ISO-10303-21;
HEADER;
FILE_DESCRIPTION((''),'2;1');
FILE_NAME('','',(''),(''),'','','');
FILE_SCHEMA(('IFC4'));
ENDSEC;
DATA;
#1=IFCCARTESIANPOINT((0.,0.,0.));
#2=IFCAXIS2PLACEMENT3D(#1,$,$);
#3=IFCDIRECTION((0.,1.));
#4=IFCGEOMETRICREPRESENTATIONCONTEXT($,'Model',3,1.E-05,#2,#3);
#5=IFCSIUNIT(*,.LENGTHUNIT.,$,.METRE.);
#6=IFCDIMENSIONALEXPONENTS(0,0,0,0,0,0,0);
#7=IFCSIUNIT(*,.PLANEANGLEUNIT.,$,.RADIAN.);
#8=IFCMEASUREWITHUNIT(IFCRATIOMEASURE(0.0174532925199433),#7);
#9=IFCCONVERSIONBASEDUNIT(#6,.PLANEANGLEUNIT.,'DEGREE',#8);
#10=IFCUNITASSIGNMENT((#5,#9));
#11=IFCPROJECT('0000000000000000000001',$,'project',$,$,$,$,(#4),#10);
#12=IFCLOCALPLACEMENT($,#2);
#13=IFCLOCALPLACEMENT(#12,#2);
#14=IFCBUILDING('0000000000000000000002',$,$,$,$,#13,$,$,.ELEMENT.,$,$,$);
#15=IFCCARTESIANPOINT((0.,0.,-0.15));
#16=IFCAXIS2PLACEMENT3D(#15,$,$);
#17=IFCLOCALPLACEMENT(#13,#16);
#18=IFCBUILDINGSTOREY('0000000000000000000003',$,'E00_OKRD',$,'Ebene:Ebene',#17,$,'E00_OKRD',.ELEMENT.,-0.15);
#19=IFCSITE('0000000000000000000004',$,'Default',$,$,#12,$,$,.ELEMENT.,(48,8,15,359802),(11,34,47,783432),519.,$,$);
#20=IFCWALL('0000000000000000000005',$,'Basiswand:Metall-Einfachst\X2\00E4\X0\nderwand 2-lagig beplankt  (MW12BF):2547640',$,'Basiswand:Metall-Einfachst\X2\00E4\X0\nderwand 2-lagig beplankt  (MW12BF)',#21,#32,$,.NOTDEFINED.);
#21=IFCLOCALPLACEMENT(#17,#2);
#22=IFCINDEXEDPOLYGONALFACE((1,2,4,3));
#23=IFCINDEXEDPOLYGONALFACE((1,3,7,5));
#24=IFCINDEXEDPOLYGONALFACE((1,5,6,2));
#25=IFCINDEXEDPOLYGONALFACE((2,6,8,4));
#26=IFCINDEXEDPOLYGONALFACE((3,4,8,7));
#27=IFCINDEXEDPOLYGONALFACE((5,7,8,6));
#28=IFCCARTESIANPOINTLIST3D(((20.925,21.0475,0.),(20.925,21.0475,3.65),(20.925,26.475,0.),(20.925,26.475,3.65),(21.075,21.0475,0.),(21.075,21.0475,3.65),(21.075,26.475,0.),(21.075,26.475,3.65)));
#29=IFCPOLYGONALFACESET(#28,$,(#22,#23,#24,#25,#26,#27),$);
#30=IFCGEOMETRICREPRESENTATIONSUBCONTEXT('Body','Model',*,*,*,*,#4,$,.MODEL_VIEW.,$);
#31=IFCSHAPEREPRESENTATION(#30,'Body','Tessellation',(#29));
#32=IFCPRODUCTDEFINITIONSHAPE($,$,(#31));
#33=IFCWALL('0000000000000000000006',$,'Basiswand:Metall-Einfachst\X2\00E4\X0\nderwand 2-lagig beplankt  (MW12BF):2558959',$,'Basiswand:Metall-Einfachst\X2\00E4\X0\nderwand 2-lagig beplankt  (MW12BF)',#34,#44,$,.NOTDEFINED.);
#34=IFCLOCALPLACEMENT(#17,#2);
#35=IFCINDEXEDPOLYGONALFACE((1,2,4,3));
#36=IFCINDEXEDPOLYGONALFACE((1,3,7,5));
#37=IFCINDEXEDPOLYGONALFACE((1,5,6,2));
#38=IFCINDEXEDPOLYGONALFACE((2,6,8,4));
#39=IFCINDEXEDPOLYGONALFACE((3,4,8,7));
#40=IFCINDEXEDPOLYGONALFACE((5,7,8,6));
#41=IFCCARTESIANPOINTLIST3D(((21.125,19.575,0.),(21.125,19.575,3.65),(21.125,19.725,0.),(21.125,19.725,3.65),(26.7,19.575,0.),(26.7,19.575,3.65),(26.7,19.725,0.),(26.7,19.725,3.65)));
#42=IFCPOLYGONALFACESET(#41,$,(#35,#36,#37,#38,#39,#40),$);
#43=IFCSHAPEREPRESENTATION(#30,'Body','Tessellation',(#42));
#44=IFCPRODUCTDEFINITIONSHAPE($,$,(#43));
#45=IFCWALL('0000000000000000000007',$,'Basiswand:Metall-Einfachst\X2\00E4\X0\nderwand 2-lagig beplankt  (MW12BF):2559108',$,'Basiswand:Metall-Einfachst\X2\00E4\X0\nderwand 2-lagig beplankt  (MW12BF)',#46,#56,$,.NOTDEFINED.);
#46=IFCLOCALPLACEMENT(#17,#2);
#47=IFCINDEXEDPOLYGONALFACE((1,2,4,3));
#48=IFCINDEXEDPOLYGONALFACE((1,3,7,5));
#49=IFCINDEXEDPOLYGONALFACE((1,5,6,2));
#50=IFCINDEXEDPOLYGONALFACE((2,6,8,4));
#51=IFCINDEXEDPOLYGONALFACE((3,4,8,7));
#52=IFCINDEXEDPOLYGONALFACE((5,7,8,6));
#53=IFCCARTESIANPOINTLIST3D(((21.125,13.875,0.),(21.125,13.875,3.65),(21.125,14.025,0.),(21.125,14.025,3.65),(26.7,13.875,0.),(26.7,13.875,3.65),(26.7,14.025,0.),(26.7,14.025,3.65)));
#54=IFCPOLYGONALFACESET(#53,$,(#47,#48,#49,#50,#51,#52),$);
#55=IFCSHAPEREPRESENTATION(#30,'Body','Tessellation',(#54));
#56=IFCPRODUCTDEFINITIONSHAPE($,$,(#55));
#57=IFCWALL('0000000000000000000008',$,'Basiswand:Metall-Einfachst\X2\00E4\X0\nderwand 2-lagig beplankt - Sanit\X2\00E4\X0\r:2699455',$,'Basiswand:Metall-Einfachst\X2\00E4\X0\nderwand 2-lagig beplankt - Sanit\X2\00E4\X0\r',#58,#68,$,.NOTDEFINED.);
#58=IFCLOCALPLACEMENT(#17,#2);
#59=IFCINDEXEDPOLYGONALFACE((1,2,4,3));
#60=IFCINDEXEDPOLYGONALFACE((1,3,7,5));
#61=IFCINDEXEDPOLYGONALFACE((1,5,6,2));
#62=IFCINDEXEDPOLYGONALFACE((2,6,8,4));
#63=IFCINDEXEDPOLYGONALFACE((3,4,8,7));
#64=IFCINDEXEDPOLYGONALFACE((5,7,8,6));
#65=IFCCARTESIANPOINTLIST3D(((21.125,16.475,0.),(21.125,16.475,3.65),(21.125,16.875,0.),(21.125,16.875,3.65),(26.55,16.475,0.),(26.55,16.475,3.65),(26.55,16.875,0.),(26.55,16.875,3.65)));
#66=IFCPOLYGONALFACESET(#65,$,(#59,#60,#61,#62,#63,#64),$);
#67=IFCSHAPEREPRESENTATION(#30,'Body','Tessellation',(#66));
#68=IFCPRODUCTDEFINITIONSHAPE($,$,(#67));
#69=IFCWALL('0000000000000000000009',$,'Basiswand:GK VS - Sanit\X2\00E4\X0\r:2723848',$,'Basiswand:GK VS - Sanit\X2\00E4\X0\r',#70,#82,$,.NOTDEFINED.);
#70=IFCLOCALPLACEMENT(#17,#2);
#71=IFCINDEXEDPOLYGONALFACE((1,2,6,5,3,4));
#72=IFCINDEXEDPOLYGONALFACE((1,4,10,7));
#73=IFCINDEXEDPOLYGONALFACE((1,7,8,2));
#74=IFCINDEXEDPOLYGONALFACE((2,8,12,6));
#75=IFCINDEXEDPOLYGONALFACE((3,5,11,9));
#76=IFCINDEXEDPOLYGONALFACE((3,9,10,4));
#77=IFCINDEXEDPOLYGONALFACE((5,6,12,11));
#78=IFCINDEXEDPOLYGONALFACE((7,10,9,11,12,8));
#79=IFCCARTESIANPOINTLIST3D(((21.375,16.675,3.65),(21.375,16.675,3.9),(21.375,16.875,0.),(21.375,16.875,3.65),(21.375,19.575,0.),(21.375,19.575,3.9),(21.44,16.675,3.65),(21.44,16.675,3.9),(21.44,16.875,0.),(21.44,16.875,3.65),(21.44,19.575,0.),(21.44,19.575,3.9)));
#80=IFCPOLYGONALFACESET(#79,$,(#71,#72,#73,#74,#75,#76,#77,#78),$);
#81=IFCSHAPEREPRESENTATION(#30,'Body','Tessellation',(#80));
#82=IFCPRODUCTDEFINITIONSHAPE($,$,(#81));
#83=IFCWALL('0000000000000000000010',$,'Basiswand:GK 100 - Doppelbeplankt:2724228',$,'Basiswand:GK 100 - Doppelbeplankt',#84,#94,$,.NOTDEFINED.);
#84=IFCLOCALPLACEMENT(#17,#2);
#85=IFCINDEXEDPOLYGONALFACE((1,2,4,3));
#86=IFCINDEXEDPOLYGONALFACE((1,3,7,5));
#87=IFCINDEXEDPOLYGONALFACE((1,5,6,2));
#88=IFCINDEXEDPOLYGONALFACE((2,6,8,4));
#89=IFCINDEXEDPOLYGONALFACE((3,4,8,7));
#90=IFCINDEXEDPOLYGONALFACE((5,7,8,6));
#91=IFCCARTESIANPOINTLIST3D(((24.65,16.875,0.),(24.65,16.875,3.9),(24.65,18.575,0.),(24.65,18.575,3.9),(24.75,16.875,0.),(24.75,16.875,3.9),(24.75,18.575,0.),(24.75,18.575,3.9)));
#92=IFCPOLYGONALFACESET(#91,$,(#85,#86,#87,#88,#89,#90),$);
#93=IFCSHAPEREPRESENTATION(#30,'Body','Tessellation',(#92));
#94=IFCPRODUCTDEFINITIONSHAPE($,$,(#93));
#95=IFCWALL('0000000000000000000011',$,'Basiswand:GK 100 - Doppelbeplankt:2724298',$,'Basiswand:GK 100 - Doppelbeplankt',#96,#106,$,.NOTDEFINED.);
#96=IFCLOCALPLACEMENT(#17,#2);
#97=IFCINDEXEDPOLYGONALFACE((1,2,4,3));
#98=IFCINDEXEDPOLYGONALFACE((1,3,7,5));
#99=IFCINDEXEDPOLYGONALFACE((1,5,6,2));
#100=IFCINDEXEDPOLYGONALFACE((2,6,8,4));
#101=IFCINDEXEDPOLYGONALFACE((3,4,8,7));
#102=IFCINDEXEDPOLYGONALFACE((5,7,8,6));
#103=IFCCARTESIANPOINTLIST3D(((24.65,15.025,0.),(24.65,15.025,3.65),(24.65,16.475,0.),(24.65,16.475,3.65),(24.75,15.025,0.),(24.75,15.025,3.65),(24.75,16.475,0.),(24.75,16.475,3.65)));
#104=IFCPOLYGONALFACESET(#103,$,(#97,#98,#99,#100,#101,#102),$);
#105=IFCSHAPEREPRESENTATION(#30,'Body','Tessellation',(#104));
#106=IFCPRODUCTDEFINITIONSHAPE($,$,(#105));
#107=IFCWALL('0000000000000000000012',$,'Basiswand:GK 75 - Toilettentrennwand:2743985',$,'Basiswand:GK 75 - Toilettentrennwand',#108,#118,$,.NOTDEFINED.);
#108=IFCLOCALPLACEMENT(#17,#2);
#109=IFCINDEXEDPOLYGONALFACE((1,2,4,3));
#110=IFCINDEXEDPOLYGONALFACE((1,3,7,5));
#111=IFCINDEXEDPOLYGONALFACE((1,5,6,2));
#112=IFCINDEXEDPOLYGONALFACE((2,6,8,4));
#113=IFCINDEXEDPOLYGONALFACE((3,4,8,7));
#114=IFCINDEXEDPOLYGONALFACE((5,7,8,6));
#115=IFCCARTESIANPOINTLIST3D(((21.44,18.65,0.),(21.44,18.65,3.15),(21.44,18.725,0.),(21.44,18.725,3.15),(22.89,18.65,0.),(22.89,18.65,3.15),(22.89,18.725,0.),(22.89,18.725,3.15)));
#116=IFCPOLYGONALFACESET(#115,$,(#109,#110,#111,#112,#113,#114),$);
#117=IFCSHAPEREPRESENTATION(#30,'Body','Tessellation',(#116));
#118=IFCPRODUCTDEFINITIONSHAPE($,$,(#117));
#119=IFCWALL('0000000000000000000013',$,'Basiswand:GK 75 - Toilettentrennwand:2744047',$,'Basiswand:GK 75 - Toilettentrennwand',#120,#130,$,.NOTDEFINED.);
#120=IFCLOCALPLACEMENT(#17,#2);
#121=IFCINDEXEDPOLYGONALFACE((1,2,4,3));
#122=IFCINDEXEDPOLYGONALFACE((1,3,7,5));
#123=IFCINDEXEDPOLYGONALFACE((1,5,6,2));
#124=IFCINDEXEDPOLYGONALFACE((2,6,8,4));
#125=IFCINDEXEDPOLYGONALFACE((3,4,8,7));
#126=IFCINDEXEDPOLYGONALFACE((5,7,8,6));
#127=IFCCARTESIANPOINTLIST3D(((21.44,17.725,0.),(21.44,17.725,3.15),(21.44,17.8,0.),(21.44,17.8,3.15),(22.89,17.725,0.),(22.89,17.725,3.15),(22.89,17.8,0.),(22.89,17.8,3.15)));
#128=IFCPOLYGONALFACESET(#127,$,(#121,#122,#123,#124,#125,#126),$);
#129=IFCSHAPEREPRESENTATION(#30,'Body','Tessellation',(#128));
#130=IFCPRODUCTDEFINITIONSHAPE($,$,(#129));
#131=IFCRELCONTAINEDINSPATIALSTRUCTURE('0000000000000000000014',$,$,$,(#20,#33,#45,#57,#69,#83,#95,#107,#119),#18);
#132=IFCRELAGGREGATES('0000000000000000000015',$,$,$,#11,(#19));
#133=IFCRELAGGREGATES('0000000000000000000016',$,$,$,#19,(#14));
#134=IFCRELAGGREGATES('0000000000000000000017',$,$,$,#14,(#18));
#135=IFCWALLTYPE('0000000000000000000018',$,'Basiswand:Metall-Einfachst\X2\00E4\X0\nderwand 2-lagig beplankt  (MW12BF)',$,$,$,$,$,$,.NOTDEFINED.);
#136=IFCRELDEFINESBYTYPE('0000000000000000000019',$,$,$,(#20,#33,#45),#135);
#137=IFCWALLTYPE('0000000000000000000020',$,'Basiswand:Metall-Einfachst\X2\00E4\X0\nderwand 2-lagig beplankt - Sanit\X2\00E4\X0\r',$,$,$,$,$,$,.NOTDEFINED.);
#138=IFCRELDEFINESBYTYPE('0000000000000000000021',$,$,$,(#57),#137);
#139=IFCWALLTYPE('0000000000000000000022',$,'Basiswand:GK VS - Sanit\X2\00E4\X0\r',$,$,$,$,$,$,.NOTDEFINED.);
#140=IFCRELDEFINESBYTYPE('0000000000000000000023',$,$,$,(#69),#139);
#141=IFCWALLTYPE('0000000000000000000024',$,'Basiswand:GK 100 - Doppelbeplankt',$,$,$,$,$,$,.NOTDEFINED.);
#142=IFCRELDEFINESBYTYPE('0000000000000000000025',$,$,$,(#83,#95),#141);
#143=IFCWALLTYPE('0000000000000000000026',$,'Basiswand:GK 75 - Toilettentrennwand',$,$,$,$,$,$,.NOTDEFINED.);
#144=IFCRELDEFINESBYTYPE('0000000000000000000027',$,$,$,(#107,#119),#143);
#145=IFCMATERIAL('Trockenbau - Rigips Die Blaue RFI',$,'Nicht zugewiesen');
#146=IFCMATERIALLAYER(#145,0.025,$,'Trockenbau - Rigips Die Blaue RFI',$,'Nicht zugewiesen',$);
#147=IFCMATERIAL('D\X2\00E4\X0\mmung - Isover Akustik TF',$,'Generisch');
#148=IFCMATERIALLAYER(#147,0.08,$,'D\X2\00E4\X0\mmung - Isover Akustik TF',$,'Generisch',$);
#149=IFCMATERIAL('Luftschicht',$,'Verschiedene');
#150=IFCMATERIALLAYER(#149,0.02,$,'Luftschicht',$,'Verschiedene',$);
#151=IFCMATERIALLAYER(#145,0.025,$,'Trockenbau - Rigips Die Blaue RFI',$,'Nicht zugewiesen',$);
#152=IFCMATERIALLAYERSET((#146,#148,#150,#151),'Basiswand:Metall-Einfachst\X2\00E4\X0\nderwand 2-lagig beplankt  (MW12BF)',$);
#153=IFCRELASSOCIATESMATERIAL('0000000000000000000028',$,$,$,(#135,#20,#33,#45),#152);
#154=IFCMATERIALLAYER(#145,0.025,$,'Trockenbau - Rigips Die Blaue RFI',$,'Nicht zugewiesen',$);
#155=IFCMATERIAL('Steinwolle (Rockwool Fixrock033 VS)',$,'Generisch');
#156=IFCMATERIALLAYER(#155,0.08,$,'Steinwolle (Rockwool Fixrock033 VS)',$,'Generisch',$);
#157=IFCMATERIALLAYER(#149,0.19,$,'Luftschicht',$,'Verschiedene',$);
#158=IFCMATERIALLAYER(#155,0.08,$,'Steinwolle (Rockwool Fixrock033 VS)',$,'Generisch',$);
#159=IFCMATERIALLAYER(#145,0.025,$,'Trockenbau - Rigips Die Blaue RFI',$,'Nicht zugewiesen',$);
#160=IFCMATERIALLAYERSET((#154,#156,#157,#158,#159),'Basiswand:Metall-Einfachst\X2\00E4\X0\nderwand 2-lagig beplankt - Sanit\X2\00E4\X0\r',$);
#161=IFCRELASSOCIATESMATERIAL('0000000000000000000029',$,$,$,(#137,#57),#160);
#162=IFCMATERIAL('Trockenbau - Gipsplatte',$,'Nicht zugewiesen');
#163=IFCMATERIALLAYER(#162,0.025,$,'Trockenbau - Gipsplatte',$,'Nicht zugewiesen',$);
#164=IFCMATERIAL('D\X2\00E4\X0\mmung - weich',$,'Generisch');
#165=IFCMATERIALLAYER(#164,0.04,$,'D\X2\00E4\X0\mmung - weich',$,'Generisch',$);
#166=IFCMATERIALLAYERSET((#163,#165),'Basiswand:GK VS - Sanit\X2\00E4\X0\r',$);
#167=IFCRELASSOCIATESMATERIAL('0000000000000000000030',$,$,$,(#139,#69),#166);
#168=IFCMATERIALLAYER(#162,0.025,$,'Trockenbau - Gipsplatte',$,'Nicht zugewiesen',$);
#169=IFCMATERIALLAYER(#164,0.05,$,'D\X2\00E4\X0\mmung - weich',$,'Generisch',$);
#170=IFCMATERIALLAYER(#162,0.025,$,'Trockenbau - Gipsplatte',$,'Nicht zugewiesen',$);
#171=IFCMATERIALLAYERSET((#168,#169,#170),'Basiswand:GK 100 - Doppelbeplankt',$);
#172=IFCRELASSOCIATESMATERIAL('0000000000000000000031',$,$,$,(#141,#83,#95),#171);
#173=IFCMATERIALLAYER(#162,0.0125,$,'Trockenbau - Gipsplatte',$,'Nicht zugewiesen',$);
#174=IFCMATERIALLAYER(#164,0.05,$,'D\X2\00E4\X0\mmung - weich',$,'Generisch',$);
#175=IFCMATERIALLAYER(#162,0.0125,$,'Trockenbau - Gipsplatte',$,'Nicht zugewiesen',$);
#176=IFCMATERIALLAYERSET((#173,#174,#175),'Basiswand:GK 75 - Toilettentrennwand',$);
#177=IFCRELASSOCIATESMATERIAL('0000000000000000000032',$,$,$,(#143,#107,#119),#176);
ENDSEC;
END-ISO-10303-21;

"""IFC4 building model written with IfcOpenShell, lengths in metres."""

from ifc_helpers import new_model, entity, si_unit, converted_unit, direction, frame, frame_2d, origin, place, context, subcontext, project, spatial, polyline, rectangle, extrude, clip, bounded_halfspace, material, layer, layer_set, layer_usage, type_object, element, save


model = new_model("IFC4")

# Units and contexts
model_context = context("Model", 3, precision=1e-05, world=origin(), true_north=direction((0.0, 1.0)))
body_context = subcontext(model_context, "Body", "Model", "MODEL_VIEW")
ifc_project = project(units=[si_unit("LENGTHUNIT", "METRE"), converted_unit("PLANEANGLEUNIT", "DEGREE", entity("IfcRatioMeasure", 0.0174532925199433), si_unit("PLANEANGLEUNIT", "RADIAN"), dimensions=[0, 0, 0, 0, 0, 0, 0])], contexts=[model_context])

# Site, building, storey
site_placement = place(None, frame((0.0, 0.0, 0.0)))
site = spatial("IfcSite", under=ifc_project, at=site_placement, Name="Default", CompositionType="ELEMENT", RefLatitude=(48, 8, 15, 359802), RefLongitude=(11, 34, 47, 783432), RefElevation=519.0)
building_placement = place(site_placement, origin())
building = spatial("IfcBuilding", under=site, at=building_placement, CompositionType="ELEMENT")
storey_placement = place(building_placement, frame((0.0, 0.0, -0.15)))
storey = spatial("IfcBuildingStorey", under=building, at=storey_placement, Name="E00_OKRD", ObjectType="Ebene:Ebene", LongName="E00_OKRD", CompositionType="ELEMENT", Elevation=-0.15)

# Walls
ifc_material_1 = material(Name="Trockenbau - Rigips Die Blaue RFI", Category="Nicht zugewiesen")
ifc_layer_1 = layer(ifc_material_1, 0.025, Name="Trockenbau - Rigips Die Blaue RFI", Category="Nicht zugewiesen")
ifc_material_2 = material(Name="Dämmung - Isover Akustik TF", Category="Generisch")
ifc_layer_2 = layer(ifc_material_2, 0.08, Name="Dämmung - Isover Akustik TF", Category="Generisch")
ifc_material_3 = material(Name="Luftschicht", Category="Verschiedene")
ifc_layer_3 = layer(ifc_material_3, 0.02, Name="Luftschicht", Category="Verschiedene")
ifc_layer_4 = layer(ifc_material_1, 0.025, Name="Trockenbau - Rigips Die Blaue RFI", Category="Nicht zugewiesen")
ifc_layer_set_1 = layer_set([ifc_layer_1, ifc_layer_2, ifc_layer_3, ifc_layer_4], Name="Basiswand:Metall-Einfachständerwand 2-lagig beplankt  (MW12BF)")
wall_type_1 = type_object("IfcWallType", Name="Basiswand:Metall-Einfachständerwand 2-lagig beplankt  (MW12BF)", PredefinedType="NOTDEFINED", material=ifc_layer_set_1)
ifc_layer_usage_1 = layer_usage(ifc_layer_set_1, "AXIS2", "NEGATIVE", 0.075)
wall_1_placement = place(storey_placement, frame((21.0, 26.475, 0.0), z_axis=(0.0, 0.0, 1.0), x_axis=(0.0, -1.0, 0.0)))
element("IfcWall", 1, at=wall_1_placement, inside=storey, type_object=wall_type_1, material=ifc_layer_usage_1, Name="Basiswand:Metall-Einfachständerwand 2-lagig beplankt  (MW12BF):2547640", ObjectType="Basiswand:Metall-Einfachständerwand 2-lagig beplankt  (MW12BF)", PredefinedType="NOTDEFINED", context=body_context, shape_type="SweptSolid", body=[
    extrude(rectangle(XDim=5.4275, YDim=0.15, at=frame_2d((2.7137, 0.0), x_axis=(-1.0, 0.0))), origin(), (0.0, 0.0, 1.0), 3.65),
])
ifc_layer_usage_2 = layer_usage(ifc_layer_set_1, "AXIS2", "NEGATIVE", 0.075)
wall_2_placement = place(storey_placement, frame((21.125, 19.65, 0.0)))
element("IfcWall", 2, at=wall_2_placement, inside=storey, type_object=wall_type_1, material=ifc_layer_usage_2, Name="Basiswand:Metall-Einfachständerwand 2-lagig beplankt  (MW12BF):2558959", ObjectType="Basiswand:Metall-Einfachständerwand 2-lagig beplankt  (MW12BF)", PredefinedType="NOTDEFINED", context=body_context, shape_type="SweptSolid", body=[
    extrude(rectangle(XDim=5.575, YDim=0.15, at=frame_2d((2.7875, 0.0), x_axis=(-1.0, 0.0))), origin(), (0.0, 0.0, 1.0), 3.65),
])
ifc_layer_usage_3 = layer_usage(ifc_layer_set_1, "AXIS2", "POSITIVE", -0.075)
wall_3_placement = place(storey_placement, frame((21.125, 13.95, 0.0)))
element("IfcWall", 3, at=wall_3_placement, inside=storey, type_object=wall_type_1, material=ifc_layer_usage_3, Name="Basiswand:Metall-Einfachständerwand 2-lagig beplankt  (MW12BF):2559108", ObjectType="Basiswand:Metall-Einfachständerwand 2-lagig beplankt  (MW12BF)", PredefinedType="NOTDEFINED", context=body_context, shape_type="SweptSolid", body=[
    extrude(rectangle(XDim=5.575, YDim=0.15, at=frame_2d((2.7875, 0.0), x_axis=(-1.0, 0.0))), origin(), (0.0, 0.0, 1.0), 3.65),
])
ifc_layer_5 = layer(ifc_material_1, 0.025, Name="Trockenbau - Rigips Die Blaue RFI", Category="Nicht zugewiesen")
ifc_material_4 = material(Name="Steinwolle (Rockwool Fixrock033 VS)", Category="Generisch")
ifc_layer_6 = layer(ifc_material_4, 0.08, Name="Steinwolle (Rockwool Fixrock033 VS)", Category="Generisch")
ifc_layer_7 = layer(ifc_material_3, 0.19, Name="Luftschicht", Category="Verschiedene")
ifc_layer_8 = layer(ifc_material_4, 0.08, Name="Steinwolle (Rockwool Fixrock033 VS)", Category="Generisch")
ifc_layer_9 = layer(ifc_material_1, 0.025, Name="Trockenbau - Rigips Die Blaue RFI", Category="Nicht zugewiesen")
ifc_layer_set_2 = layer_set([ifc_layer_5, ifc_layer_6, ifc_layer_7, ifc_layer_8, ifc_layer_9], Name="Basiswand:Metall-Einfachständerwand 2-lagig beplankt - Sanitär")
ifc_layer_usage_4 = layer_usage(ifc_layer_set_2, "AXIS2", "NEGATIVE", 0.2)
wall_type_2 = type_object("IfcWallType", Name="Basiswand:Metall-Einfachständerwand 2-lagig beplankt - Sanitär", PredefinedType="NOTDEFINED", material=ifc_layer_set_2)
wall_4_placement = place(storey_placement, frame((21.125, 16.675, 0.0)))
element("IfcWall", 4, at=wall_4_placement, inside=storey, type_object=wall_type_2, material=ifc_layer_usage_4, Name="Basiswand:Metall-Einfachständerwand 2-lagig beplankt - Sanitär:2699455", ObjectType="Basiswand:Metall-Einfachständerwand 2-lagig beplankt - Sanitär", PredefinedType="NOTDEFINED", context=body_context, shape_type="SweptSolid", body=[
    extrude(rectangle(XDim=5.425, YDim=0.4, at=frame_2d((2.7125, 0.0), x_axis=(-1.0, 0.0))), origin(), (0.0, 0.0, 1.0), 3.65),
])
ifc_material_5 = material(Name="Trockenbau - Gipsplatte", Category="Nicht zugewiesen")
ifc_layer_10 = layer(ifc_material_5, 0.025, Name="Trockenbau - Gipsplatte", Category="Nicht zugewiesen")
ifc_material_6 = material(Name="Dämmung - weich", Category="Generisch")
ifc_layer_11 = layer(ifc_material_6, 0.04, Name="Dämmung - weich", Category="Generisch")
ifc_layer_set_3 = layer_set([ifc_layer_10, ifc_layer_11], Name="Basiswand:GK VS - Sanitär")
ifc_layer_usage_5 = layer_usage(ifc_layer_set_3, "AXIS2", "NEGATIVE", 0.0325)
wall_type_3 = type_object("IfcWallType", Name="Basiswand:GK VS - Sanitär", PredefinedType="NOTDEFINED", material=ifc_layer_set_3)
wall_5_placement = place(storey_placement, frame((21.4075, 19.575, 0.0), z_axis=(0.0, 0.0, 1.0), x_axis=(0.0, -1.0, 0.0)))
element("IfcWall", 5, at=wall_5_placement, inside=storey, type_object=wall_type_3, material=ifc_layer_usage_5, Name="Basiswand:GK VS - Sanitär:2723848", ObjectType="Basiswand:GK VS - Sanitär", PredefinedType="NOTDEFINED", context=body_context, shape_type="Clipping", body=[
    clip(clip(extrude(rectangle(XDim=2.9, YDim=0.065, at=frame_2d((1.45, 0.0), x_axis=(-1.0, 0.0))), origin(), (0.0, 0.0, 1.0), 3.9), bounded_halfspace(frame((2.7, 0.0325, 3.65), z_axis=(-1.0, 0.0, 0.0), x_axis=(0.0, -1.0, 0.0)), True, frame((2.7, 0.0325, 3.65), z_axis=(-1.0, 0.0, 0.0), x_axis=(0.0, -1.0, 0.0)), polyline([(0.0, 0.0), (0.0, -3.65), (0.065, -3.65), (0.065, 0.0), (0.0, 0.0)]))), bounded_halfspace(frame((2.7, -0.0325, 3.65), z_axis=(0.0, 0.0, 1.0), x_axis=(-1.0, 0.0, 0.0)), True, frame((2.7, -0.0325, 3.65), z_axis=(0.0, 0.0, 1.0), x_axis=(-1.0, 0.0, 0.0)), polyline([(0.0, 0.0), (-0.2, 0.0), (-0.2, -0.065), (0.0, -0.065), (0.0, 0.0)]))),
])
ifc_layer_12 = layer(ifc_material_5, 0.025, Name="Trockenbau - Gipsplatte", Category="Nicht zugewiesen")
ifc_layer_13 = layer(ifc_material_6, 0.05, Name="Dämmung - weich", Category="Generisch")
ifc_layer_14 = layer(ifc_material_5, 0.025, Name="Trockenbau - Gipsplatte", Category="Nicht zugewiesen")
ifc_layer_set_4 = layer_set([ifc_layer_12, ifc_layer_13, ifc_layer_14], Name="Basiswand:GK 100 - Doppelbeplankt")
ifc_layer_usage_6 = layer_usage(ifc_layer_set_4, "AXIS2", "NEGATIVE", 0.05)
wall_type_4 = type_object("IfcWallType", Name="Basiswand:GK 100 - Doppelbeplankt", PredefinedType="NOTDEFINED", material=ifc_layer_set_4)
wall_6_placement = place(storey_placement, frame((24.7, 16.875, 0.0), z_axis=(0.0, 0.0, 1.0), x_axis=(0.0, 1.0, 0.0)))
element("IfcWall", 6, at=wall_6_placement, inside=storey, type_object=wall_type_4, material=ifc_layer_usage_6, Name="Basiswand:GK 100 - Doppelbeplankt:2724228", ObjectType="Basiswand:GK 100 - Doppelbeplankt", PredefinedType="NOTDEFINED", context=body_context, shape_type="SweptSolid", body=[
    extrude(rectangle(XDim=1.7, YDim=0.1, at=frame_2d((0.85, 0.0), x_axis=(-1.0, 0.0))), origin(), (0.0, 0.0, 1.0), 3.9),
])
ifc_layer_usage_7 = layer_usage(ifc_layer_set_4, "AXIS2", "NEGATIVE", 0.05)
wall_7_placement = place(storey_placement, frame((24.7, 16.475, 0.0), z_axis=(0.0, 0.0, 1.0), x_axis=(0.0, -1.0, 0.0)))
element("IfcWall", 7, at=wall_7_placement, inside=storey, type_object=wall_type_4, material=ifc_layer_usage_7, Name="Basiswand:GK 100 - Doppelbeplankt:2724298", ObjectType="Basiswand:GK 100 - Doppelbeplankt", PredefinedType="NOTDEFINED", context=body_context, shape_type="SweptSolid", body=[
    extrude(rectangle(XDim=1.45, YDim=0.1, at=frame_2d((0.725, 0.0), x_axis=(-1.0, 0.0))), origin(), (0.0, 0.0, 1.0), 3.65),
])
ifc_layer_15 = layer(ifc_material_5, 0.0125, Name="Trockenbau - Gipsplatte", Category="Nicht zugewiesen")
ifc_layer_16 = layer(ifc_material_6, 0.05, Name="Dämmung - weich", Category="Generisch")
ifc_layer_17 = layer(ifc_material_5, 0.0125, Name="Trockenbau - Gipsplatte", Category="Nicht zugewiesen")
ifc_layer_set_5 = layer_set([ifc_layer_15, ifc_layer_16, ifc_layer_17], Name="Basiswand:GK 75 - Toilettentrennwand")
ifc_layer_usage_8 = layer_usage(ifc_layer_set_5, "AXIS2", "NEGATIVE", 0.0375)
wall_type_5 = type_object("IfcWallType", Name="Basiswand:GK 75 - Toilettentrennwand", PredefinedType="NOTDEFINED", material=ifc_layer_set_5)
wall_8_placement = place(storey_placement, frame((21.44, 18.6875, 0.0)))
element("IfcWall", 8, at=wall_8_placement, inside=storey, type_object=wall_type_5, material=ifc_layer_usage_8, Name="Basiswand:GK 75 - Toilettentrennwand:2743985", ObjectType="Basiswand:GK 75 - Toilettentrennwand", PredefinedType="NOTDEFINED", context=body_context, shape_type="SweptSolid", body=[
    extrude(rectangle(XDim=1.45, YDim=0.075, at=frame_2d((0.725, 0.0), x_axis=(-1.0, 0.0))), origin(), (0.0, 0.0, 1.0), 3.15),
])
ifc_layer_usage_9 = layer_usage(ifc_layer_set_5, "AXIS2", "NEGATIVE", 0.0375)
wall_9_placement = place(storey_placement, frame((21.44, 17.7625, 0.0)))
element("IfcWall", 9, at=wall_9_placement, inside=storey, type_object=wall_type_5, material=ifc_layer_usage_9, Name="Basiswand:GK 75 - Toilettentrennwand:2744047", ObjectType="Basiswand:GK 75 - Toilettentrennwand", PredefinedType="NOTDEFINED", context=body_context, shape_type="SweptSolid", body=[
    extrude(rectangle(XDim=1.45, YDim=0.075, at=frame_2d((0.725, 0.0), x_axis=(-1.0, 0.0))), origin(), (0.0, 0.0, 1.0), 3.15),
])

save(model, "model.ifc")
